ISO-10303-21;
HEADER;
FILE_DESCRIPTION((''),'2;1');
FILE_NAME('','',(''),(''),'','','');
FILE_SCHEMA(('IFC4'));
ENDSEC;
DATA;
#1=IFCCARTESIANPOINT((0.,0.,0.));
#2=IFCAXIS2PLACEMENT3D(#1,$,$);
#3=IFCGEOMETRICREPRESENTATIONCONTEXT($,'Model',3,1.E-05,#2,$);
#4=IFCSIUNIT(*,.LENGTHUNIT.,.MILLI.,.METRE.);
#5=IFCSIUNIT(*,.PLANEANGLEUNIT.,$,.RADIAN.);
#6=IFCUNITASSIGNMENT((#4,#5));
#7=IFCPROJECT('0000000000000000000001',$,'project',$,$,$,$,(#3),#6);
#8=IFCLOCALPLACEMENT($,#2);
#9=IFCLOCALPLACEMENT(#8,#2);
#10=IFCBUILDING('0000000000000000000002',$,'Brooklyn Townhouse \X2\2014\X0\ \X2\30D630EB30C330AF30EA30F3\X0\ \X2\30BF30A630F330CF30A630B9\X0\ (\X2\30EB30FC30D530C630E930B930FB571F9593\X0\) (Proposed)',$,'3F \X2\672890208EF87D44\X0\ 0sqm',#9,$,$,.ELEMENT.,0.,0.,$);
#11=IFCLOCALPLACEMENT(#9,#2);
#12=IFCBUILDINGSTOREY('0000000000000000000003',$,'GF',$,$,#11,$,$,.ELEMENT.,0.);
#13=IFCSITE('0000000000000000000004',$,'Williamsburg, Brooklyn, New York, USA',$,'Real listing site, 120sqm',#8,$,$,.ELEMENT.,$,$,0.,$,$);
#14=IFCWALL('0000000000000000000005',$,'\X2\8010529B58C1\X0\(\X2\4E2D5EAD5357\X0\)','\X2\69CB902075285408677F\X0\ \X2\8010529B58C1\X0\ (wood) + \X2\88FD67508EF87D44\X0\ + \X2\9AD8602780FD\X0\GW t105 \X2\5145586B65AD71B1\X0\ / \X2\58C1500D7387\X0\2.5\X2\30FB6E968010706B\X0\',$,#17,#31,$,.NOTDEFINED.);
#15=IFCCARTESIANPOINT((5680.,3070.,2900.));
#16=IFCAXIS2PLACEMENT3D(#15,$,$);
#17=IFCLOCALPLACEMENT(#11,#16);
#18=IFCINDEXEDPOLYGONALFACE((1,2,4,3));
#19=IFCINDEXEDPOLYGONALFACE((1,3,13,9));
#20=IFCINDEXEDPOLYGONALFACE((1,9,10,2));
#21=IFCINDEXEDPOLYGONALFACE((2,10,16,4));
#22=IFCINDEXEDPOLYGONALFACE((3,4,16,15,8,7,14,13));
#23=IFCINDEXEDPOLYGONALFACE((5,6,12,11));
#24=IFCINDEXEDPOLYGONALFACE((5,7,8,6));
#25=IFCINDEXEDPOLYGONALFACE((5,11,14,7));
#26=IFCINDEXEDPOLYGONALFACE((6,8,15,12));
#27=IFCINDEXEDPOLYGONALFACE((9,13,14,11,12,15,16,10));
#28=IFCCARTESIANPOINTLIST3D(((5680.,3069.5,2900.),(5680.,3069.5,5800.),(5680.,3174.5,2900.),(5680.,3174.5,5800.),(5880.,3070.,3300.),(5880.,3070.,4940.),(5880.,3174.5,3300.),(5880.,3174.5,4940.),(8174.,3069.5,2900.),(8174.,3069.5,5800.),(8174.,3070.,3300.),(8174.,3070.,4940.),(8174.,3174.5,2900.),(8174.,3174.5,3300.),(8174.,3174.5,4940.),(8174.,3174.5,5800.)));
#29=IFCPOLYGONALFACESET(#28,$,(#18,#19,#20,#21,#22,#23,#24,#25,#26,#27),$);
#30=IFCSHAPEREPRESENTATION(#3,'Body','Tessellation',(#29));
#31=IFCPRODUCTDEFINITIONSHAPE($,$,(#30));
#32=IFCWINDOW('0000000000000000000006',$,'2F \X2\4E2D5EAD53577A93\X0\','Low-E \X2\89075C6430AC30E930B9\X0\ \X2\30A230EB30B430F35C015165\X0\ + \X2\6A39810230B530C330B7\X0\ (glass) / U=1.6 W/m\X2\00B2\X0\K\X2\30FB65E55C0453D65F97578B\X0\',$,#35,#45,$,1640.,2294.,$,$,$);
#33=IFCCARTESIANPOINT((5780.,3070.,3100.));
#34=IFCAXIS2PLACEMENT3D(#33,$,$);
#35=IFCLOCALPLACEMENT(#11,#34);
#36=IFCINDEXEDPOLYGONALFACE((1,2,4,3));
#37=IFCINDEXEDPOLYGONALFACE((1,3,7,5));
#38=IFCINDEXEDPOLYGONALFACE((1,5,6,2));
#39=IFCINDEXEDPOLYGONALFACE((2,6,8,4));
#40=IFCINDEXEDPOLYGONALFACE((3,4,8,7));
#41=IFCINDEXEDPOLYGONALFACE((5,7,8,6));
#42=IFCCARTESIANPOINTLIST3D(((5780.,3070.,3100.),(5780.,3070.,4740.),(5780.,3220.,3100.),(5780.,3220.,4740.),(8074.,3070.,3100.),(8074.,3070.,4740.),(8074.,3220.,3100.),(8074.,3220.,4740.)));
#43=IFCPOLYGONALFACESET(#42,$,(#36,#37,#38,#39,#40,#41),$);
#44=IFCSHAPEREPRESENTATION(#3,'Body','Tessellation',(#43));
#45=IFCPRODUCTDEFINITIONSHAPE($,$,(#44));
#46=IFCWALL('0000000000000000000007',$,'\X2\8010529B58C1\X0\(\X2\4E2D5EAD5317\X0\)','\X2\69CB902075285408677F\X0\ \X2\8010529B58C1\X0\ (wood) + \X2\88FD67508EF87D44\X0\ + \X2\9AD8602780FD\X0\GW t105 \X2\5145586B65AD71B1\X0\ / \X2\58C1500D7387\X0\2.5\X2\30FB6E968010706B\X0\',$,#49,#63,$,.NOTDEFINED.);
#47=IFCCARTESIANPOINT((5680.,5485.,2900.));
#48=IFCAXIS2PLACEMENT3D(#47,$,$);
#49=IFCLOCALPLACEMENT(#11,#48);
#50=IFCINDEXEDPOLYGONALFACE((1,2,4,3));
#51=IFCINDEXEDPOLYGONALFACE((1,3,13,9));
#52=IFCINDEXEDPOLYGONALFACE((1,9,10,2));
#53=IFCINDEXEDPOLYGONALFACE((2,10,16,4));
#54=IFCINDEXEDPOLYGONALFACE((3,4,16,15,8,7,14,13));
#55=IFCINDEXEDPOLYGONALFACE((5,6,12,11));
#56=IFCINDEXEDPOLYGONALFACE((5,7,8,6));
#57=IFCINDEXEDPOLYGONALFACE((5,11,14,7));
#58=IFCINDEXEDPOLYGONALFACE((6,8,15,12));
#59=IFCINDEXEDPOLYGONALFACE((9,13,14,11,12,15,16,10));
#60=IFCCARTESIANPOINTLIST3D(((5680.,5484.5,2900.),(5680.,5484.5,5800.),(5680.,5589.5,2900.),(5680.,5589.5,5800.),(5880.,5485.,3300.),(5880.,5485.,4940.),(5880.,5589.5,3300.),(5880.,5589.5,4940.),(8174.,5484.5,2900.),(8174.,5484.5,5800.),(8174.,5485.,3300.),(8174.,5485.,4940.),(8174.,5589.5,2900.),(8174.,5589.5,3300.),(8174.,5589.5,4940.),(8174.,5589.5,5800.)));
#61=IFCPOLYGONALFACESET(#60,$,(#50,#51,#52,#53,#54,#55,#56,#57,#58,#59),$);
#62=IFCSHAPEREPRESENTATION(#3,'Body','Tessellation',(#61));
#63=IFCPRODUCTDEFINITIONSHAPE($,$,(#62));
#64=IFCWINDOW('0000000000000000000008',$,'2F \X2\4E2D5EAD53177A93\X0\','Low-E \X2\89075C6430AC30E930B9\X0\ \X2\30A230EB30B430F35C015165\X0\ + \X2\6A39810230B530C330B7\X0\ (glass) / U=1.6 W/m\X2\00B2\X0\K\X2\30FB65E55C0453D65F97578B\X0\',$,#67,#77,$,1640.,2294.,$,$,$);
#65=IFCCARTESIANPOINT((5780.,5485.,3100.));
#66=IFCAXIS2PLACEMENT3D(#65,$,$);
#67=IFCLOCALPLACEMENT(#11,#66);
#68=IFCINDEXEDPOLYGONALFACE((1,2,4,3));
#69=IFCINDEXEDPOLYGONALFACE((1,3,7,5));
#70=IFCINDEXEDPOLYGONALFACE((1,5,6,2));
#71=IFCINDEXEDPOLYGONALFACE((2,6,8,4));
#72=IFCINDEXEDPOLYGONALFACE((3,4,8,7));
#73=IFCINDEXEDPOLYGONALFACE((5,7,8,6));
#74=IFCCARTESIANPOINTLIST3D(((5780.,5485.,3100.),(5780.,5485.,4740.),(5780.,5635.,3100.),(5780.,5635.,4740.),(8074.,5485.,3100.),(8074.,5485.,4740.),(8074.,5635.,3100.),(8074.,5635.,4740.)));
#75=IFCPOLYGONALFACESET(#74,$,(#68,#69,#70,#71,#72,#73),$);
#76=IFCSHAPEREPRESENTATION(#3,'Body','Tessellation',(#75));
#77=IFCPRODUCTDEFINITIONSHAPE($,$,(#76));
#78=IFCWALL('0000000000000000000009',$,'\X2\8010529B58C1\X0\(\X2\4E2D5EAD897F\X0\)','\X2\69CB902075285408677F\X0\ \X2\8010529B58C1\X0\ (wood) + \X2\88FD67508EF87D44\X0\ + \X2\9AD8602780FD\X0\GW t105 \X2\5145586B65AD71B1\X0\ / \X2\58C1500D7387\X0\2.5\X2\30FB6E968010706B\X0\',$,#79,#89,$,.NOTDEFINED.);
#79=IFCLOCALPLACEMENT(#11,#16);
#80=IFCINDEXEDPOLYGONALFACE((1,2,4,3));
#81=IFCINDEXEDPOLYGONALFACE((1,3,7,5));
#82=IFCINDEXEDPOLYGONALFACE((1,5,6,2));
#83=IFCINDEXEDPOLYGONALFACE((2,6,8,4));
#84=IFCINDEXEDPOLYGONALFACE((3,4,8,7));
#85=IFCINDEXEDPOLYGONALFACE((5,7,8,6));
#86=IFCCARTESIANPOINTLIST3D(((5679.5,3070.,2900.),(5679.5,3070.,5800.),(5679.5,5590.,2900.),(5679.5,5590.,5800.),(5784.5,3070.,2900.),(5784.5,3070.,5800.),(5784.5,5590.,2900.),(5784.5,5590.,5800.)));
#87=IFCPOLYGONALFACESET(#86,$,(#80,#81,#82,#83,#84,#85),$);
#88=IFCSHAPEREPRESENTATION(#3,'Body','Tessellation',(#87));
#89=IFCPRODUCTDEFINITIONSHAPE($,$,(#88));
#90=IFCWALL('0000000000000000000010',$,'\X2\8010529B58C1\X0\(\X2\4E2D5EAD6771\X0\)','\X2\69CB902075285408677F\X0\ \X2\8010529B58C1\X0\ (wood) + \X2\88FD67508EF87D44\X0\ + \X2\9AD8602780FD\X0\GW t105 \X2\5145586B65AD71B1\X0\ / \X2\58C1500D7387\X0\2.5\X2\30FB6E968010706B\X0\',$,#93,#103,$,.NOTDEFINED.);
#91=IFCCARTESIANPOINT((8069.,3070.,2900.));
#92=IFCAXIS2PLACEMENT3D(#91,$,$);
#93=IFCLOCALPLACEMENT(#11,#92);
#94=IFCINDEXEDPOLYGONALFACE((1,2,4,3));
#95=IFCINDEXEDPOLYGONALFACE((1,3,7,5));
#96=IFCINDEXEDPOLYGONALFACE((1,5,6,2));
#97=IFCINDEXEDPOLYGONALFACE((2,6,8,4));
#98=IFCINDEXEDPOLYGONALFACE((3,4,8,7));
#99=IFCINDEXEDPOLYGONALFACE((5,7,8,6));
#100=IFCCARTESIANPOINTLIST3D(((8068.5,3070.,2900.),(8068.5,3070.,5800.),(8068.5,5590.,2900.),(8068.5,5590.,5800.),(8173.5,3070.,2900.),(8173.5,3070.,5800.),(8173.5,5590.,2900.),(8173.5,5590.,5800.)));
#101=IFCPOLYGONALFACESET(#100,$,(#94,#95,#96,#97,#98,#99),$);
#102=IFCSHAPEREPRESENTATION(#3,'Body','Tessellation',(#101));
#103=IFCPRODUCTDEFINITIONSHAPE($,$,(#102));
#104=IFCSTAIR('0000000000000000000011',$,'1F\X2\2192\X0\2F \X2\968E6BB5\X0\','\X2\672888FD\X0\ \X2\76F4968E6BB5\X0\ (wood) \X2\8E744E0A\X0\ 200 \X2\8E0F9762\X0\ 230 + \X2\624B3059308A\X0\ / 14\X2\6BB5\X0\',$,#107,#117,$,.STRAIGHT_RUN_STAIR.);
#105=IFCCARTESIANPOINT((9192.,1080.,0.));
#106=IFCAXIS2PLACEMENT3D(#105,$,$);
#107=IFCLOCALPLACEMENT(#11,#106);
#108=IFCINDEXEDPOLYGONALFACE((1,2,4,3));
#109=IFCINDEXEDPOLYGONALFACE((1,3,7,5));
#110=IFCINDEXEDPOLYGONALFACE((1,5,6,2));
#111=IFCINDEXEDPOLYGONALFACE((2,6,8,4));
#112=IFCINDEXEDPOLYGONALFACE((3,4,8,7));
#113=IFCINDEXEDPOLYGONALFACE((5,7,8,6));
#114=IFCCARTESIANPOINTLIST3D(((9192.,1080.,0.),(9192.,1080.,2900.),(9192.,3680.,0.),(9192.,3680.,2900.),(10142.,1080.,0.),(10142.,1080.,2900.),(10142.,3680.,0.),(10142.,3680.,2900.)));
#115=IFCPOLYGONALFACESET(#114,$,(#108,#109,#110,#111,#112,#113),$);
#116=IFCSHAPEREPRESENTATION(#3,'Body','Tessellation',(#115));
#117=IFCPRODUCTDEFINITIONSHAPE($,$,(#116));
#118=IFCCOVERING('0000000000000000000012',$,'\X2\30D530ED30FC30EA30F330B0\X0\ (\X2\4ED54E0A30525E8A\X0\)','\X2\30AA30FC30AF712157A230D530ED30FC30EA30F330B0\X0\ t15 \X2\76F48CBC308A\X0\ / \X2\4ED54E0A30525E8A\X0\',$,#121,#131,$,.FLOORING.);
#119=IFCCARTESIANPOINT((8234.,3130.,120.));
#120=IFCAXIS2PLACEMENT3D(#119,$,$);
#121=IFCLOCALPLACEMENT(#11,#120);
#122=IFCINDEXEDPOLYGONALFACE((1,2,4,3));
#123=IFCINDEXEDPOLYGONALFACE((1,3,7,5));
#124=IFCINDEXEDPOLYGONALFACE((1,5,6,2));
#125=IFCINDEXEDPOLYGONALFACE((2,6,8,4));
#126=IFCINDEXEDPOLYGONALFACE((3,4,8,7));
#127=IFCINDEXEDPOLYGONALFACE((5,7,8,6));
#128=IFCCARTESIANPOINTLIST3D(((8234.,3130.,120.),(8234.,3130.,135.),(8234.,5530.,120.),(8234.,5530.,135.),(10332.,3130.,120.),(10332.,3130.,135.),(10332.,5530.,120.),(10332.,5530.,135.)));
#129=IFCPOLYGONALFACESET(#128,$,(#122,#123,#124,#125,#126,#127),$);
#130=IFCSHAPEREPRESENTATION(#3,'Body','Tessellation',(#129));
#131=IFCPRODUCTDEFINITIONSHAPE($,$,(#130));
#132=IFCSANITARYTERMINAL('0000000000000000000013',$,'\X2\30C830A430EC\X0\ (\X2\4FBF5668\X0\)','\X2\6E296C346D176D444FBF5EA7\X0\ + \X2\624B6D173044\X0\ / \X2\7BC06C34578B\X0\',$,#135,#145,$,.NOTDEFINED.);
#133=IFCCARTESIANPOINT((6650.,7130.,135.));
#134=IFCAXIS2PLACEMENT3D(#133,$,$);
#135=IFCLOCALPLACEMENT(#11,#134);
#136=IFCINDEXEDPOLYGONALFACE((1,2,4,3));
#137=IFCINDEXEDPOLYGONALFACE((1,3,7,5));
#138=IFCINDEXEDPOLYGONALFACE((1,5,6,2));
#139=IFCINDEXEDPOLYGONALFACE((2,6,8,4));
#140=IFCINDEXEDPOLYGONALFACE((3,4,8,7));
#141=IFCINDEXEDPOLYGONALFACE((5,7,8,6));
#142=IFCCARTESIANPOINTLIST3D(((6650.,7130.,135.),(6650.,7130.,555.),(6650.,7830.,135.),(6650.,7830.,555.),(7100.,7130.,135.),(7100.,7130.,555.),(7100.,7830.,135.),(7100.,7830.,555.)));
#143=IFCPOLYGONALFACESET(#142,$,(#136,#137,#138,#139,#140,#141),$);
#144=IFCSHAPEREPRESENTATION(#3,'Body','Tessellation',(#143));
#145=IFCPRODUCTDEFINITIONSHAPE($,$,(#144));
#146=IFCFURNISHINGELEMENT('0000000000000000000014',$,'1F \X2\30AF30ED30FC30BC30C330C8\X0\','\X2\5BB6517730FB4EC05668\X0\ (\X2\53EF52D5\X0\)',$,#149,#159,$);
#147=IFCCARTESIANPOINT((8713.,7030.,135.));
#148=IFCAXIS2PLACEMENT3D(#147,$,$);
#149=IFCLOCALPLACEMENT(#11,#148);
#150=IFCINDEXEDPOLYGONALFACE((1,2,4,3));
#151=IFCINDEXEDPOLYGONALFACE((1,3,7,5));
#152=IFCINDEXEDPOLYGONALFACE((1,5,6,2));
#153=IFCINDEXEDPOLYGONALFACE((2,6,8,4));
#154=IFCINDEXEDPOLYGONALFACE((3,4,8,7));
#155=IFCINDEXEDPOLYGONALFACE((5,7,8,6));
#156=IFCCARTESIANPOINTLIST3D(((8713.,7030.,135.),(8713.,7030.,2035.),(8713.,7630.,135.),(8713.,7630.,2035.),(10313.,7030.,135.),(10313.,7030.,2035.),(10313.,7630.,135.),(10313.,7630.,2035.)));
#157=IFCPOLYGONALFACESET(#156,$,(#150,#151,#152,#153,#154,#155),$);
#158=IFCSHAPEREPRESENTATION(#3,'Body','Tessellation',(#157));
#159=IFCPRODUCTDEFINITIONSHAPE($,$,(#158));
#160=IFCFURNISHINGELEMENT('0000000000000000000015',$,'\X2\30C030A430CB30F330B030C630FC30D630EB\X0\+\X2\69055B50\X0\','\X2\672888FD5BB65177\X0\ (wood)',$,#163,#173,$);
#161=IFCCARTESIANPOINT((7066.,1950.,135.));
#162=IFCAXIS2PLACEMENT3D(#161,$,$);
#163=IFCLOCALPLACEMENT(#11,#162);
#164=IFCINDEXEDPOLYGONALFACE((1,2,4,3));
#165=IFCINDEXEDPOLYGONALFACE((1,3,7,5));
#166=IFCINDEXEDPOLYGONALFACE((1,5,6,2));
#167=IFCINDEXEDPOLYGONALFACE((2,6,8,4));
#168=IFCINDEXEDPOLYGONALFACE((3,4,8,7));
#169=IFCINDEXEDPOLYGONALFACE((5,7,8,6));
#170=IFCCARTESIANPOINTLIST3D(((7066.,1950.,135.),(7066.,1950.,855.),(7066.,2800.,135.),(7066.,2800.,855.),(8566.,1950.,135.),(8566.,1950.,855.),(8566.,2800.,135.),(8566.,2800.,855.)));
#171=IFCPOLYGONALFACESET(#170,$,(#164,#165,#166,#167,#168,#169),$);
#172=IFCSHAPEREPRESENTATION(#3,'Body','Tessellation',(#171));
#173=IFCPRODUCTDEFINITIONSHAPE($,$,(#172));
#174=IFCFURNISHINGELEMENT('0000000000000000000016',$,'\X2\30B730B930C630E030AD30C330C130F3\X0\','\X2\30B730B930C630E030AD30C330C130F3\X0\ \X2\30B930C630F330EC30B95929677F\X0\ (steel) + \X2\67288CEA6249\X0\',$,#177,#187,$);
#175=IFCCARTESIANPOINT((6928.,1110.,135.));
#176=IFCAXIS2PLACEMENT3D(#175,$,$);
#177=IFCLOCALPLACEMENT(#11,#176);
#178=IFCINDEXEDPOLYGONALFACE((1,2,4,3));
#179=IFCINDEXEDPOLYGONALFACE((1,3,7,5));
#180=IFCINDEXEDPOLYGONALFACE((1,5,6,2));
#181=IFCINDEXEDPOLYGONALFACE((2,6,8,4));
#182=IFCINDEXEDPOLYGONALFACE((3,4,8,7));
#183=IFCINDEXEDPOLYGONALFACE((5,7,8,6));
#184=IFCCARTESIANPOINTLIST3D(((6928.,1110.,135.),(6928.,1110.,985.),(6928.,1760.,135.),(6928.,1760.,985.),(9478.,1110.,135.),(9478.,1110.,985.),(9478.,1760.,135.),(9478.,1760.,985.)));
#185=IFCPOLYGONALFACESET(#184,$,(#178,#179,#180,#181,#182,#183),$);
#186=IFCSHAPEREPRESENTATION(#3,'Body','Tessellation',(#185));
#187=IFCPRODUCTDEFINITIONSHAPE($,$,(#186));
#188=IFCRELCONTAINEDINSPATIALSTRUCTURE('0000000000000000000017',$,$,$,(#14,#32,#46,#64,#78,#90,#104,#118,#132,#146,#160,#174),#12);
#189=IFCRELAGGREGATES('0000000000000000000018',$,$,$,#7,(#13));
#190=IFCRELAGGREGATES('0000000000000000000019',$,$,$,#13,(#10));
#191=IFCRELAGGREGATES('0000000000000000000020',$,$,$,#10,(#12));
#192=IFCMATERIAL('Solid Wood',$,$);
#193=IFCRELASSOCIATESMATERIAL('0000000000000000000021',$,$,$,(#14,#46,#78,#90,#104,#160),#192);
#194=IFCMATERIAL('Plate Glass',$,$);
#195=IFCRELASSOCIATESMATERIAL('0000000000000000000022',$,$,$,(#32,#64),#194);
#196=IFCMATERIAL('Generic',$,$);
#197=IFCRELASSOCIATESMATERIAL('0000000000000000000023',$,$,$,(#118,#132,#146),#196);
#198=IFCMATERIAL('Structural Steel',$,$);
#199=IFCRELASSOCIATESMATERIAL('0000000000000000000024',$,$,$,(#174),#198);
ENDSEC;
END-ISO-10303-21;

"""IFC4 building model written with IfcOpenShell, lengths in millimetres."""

from ifc_helpers import new_model, si_unit, frame, frame_2d, origin, place, context, project, spatial, rectangle, extrude, material, element, fill, save


model = new_model("IFC4")

# Units and contexts
model_context = context("Model", 3, precision=1e-05, world=origin())
ifc_project = project(units=[si_unit("LENGTHUNIT", "METRE", prefix="MILLI"), si_unit("PLANEANGLEUNIT", "RADIAN")], contexts=[model_context])

# Site, building, storey
site_placement = place(None, origin())
site = spatial("IfcSite", under=ifc_project, at=site_placement, Name="Williamsburg, Brooklyn, New York, USA", ObjectType="Real listing site, 120sqm", CompositionType="ELEMENT", RefElevation=0.0)
building_placement = place(site_placement, origin())
building = spatial("IfcBuilding", under=site, at=building_placement, Name="Brooklyn Townhouse — ブルックリン タウンハウス (ルーフテラス・土間) (Proposed)", ObjectType="3F 木造軸組 0sqm", CompositionType="ELEMENT", ElevationOfRefHeight=0.0, ElevationOfTerrain=0.0)
storey_placement = place(building_placement, origin())
storey = spatial("IfcBuildingStorey", under=building, at=storey_placement, Name="GF", CompositionType="ELEMENT", Elevation=0.0)

# Shared definitions
ifc_material_1 = material(Name="Solid Wood")

# Shared definitions
ifc_material_2 = material(Name="Plate Glass")

# Walls, openings, windows
wall_1_placement = place(storey_placement, frame((5680.0, 3070.0, 2900.0)))
wall_1 = element("IfcWall", 1, at=wall_1_placement, inside=storey, material=ifc_material_1, Name="耐力壁(中庭南)", Description="構造用合板 耐力壁 (wood) + 製材軸組 + 高性能GW t105 充填断熱 / 壁倍率2.5・準耐火", PredefinedType="NOTDEFINED", context=model_context, shape_type="SweptSolid", body=[
    extrude(rectangle(XDim=2494.0, YDim=105.0, at=frame_2d((1247.0, 52.0))), frame((5680.0, 3070.0, 2900.0)), (0.0, 0.0, 1.0), 2900.0),
])
opening_1_placement = place(storey_placement, frame((5780.0, 3070.0, 3100.0)))
opening_1 = element("IfcOpeningElement", 2, at=opening_1_placement, cuts=wall_1, PredefinedType="NOTDEFINED", context=model_context, shape_type="SweptSolid", body=[
    extrude(rectangle(XDim=2294.0, YDim=150.0, at=frame_2d((1147.0, 75.0))), frame((5780.0, 3070.0, 3100.0)), (0.0, 0.0, 1.0), 1640.0),
])
window_1_placement = place(storey_placement, frame((5780.0, 3070.0, 3100.0)))
window_1 = element("IfcWindow", 3, at=window_1_placement, inside=storey, material=ifc_material_2, Name="2F 中庭南窓", Description="Low-E 複層ガラス アルゴン封入 + 樹脂サッシ (glass) / U=1.6 W/m²K・日射取得型", OverallHeight=1640.0, OverallWidth=2294.0, context=model_context, shape_type="SweptSolid", body=[
    extrude(rectangle(XDim=2294.0, YDim=150.0, at=frame_2d((1147.0, 75.0))), frame((5780.0, 3070.0, 3100.0)), (0.0, 0.0, 1.0), 1640.0),
])
fill(opening_1, window_1)
wall_2_placement = place(storey_placement, frame((5680.0, 5485.0, 2900.0)))
wall_2 = element("IfcWall", 4, at=wall_2_placement, inside=storey, material=ifc_material_1, Name="耐力壁(中庭北)", Description="構造用合板 耐力壁 (wood) + 製材軸組 + 高性能GW t105 充填断熱 / 壁倍率2.5・準耐火", PredefinedType="NOTDEFINED", context=model_context, shape_type="SweptSolid", body=[
    extrude(rectangle(XDim=2494.0, YDim=105.0, at=frame_2d((1247.0, 52.0))), frame((5680.0, 5485.0, 2900.0)), (0.0, 0.0, 1.0), 2900.0),
])
opening_2_placement = place(storey_placement, frame((5780.0, 5485.0, 3100.0)))
opening_2 = element("IfcOpeningElement", 5, at=opening_2_placement, cuts=wall_2, PredefinedType="NOTDEFINED", context=model_context, shape_type="SweptSolid", body=[
    extrude(rectangle(XDim=2294.0, YDim=150.0, at=frame_2d((1147.0, 75.0))), frame((5780.0, 5485.0, 3100.0)), (0.0, 0.0, 1.0), 1640.0),
])
window_2_placement = place(storey_placement, frame((5780.0, 5485.0, 3100.0)))
window_2 = element("IfcWindow", 6, at=window_2_placement, inside=storey, material=ifc_material_2, Name="2F 中庭北窓", Description="Low-E 複層ガラス アルゴン封入 + 樹脂サッシ (glass) / U=1.6 W/m²K・日射取得型", OverallHeight=1640.0, OverallWidth=2294.0, context=model_context, shape_type="SweptSolid", body=[
    extrude(rectangle(XDim=2294.0, YDim=150.0, at=frame_2d((1147.0, 75.0))), frame((5780.0, 5485.0, 3100.0)), (0.0, 0.0, 1.0), 1640.0),
])
fill(opening_2, window_2)

# Walls
wall_3_placement = place(storey_placement, frame((5680.0, 3070.0, 2900.0)))
element("IfcWall", 7, at=wall_3_placement, inside=storey, material=ifc_material_1, Name="耐力壁(中庭西)", Description="構造用合板 耐力壁 (wood) + 製材軸組 + 高性能GW t105 充填断熱 / 壁倍率2.5・準耐火", PredefinedType="NOTDEFINED", context=model_context, shape_type="SweptSolid", body=[
    extrude(rectangle(XDim=105.0, YDim=2520.0, at=frame_2d((52.0, 1260.0))), frame((5680.0, 3070.0, 2900.0)), (0.0, 0.0, 1.0), 2900.0),
])
wall_4_placement = place(storey_placement, frame((8069.0, 3070.0, 2900.0)))
element("IfcWall", 8, at=wall_4_placement, inside=storey, material=ifc_material_1, Name="耐力壁(中庭東)", Description="構造用合板 耐力壁 (wood) + 製材軸組 + 高性能GW t105 充填断熱 / 壁倍率2.5・準耐火", PredefinedType="NOTDEFINED", context=model_context, shape_type="SweptSolid", body=[
    extrude(rectangle(XDim=105.0, YDim=2520.0, at=frame_2d((52.0, 1260.0))), frame((8069.0, 3070.0, 2900.0)), (0.0, 0.0, 1.0), 2900.0),
])

# Stair
stair_placement = place(storey_placement, frame((9192.0, 1080.0, 0.0)))
element("IfcStair", 9, at=stair_placement, inside=storey, material=ifc_material_1, Name="1F→2F 階段", Description="木製 直階段 (wood) 蹴上 200 踏面 230 + 手すり / 14段", PredefinedType="STRAIGHT_RUN_STAIR", context=model_context, shape_type="SweptSolid", body=[
    extrude(rectangle(XDim=950.0, YDim=2600.0, at=frame_2d((475.0, 1300.0))), frame((9192.0, 1080.0, 0.0)), (0.0, 0.0, 1.0), 2900.0),
])

# Covering
ifc_material_3 = material(Name="Generic")
covering_placement = place(storey_placement, frame((8234.0, 3130.0, 120.0)))
element("IfcCovering", 10, at=covering_placement, inside=storey, material=ifc_material_3, Name="フローリング (仕上げ床)", Description="オーク無垢フローリング t15 直貼り / 仕上げ床", PredefinedType="FLOORING", context=model_context, shape_type="SweptSolid", body=[
    extrude(rectangle(XDim=2098.0, YDim=2400.0, at=frame_2d((1049.0, 1200.0))), frame((8234.0, 3130.0, 120.0)), (0.0, 0.0, 1.0), 15.0),
])

# Sanitary terminal
sanitary_terminal_placement = place(storey_placement, frame((6650.0, 7130.0, 135.0)))
element("IfcSanitaryTerminal", 11, at=sanitary_terminal_placement, inside=storey, material=ifc_material_3, Name="トイレ (便器)", Description="温水洗浄便座 + 手洗い / 節水型", PredefinedType="NOTDEFINED", context=model_context, shape_type="SweptSolid", body=[
    extrude(rectangle(XDim=450.0, YDim=700.0, at=frame_2d((225.0, 350.0))), frame((6650.0, 7130.0, 135.0)), (0.0, 0.0, 1.0), 420.0),
])

# Furnishing elements
furnishing_1_placement = place(storey_placement, frame((8713.0, 7030.0, 135.0)))
element("IfcFurnishingElement", 12, at=furnishing_1_placement, inside=storey, material=ifc_material_3, Name="1F クローゼット", Description="家具・什器 (可動)", context=model_context, shape_type="SweptSolid", body=[
    extrude(rectangle(XDim=1600.0, YDim=600.0, at=frame_2d((800.0, 300.0))), frame((8713.0, 7030.0, 135.0)), (0.0, 0.0, 1.0), 1900.0),
])
furnishing_2_placement = place(storey_placement, frame((7066.0, 1950.0, 135.0)))
element("IfcFurnishingElement", 13, at=furnishing_2_placement, inside=storey, material=ifc_material_1, Name="ダイニングテーブル+椅子", Description="木製家具 (wood)", context=model_context, shape_type="SweptSolid", body=[
    extrude(rectangle(XDim=1500.0, YDim=850.0, at=frame_2d((750.0, 425.0))), frame((7066.0, 1950.0, 135.0)), (0.0, 0.0, 1.0), 720.0),
])
ifc_material_4 = material(Name="Structural Steel")
furnishing_3_placement = place(storey_placement, frame((6928.0, 1110.0, 135.0)))
element("IfcFurnishingElement", 14, at=furnishing_3_placement, inside=storey, material=ifc_material_4, Name="システムキッチン", Description="システムキッチン ステンレス天板 (steel) + 木質扉", context=model_context, shape_type="SweptSolid", body=[
    extrude(rectangle(XDim=2550.0, YDim=650.0, at=frame_2d((1275.0, 325.0))), frame((6928.0, 1110.0, 135.0)), (0.0, 0.0, 1.0), 850.0),
])

save(model, "model.ifc")
